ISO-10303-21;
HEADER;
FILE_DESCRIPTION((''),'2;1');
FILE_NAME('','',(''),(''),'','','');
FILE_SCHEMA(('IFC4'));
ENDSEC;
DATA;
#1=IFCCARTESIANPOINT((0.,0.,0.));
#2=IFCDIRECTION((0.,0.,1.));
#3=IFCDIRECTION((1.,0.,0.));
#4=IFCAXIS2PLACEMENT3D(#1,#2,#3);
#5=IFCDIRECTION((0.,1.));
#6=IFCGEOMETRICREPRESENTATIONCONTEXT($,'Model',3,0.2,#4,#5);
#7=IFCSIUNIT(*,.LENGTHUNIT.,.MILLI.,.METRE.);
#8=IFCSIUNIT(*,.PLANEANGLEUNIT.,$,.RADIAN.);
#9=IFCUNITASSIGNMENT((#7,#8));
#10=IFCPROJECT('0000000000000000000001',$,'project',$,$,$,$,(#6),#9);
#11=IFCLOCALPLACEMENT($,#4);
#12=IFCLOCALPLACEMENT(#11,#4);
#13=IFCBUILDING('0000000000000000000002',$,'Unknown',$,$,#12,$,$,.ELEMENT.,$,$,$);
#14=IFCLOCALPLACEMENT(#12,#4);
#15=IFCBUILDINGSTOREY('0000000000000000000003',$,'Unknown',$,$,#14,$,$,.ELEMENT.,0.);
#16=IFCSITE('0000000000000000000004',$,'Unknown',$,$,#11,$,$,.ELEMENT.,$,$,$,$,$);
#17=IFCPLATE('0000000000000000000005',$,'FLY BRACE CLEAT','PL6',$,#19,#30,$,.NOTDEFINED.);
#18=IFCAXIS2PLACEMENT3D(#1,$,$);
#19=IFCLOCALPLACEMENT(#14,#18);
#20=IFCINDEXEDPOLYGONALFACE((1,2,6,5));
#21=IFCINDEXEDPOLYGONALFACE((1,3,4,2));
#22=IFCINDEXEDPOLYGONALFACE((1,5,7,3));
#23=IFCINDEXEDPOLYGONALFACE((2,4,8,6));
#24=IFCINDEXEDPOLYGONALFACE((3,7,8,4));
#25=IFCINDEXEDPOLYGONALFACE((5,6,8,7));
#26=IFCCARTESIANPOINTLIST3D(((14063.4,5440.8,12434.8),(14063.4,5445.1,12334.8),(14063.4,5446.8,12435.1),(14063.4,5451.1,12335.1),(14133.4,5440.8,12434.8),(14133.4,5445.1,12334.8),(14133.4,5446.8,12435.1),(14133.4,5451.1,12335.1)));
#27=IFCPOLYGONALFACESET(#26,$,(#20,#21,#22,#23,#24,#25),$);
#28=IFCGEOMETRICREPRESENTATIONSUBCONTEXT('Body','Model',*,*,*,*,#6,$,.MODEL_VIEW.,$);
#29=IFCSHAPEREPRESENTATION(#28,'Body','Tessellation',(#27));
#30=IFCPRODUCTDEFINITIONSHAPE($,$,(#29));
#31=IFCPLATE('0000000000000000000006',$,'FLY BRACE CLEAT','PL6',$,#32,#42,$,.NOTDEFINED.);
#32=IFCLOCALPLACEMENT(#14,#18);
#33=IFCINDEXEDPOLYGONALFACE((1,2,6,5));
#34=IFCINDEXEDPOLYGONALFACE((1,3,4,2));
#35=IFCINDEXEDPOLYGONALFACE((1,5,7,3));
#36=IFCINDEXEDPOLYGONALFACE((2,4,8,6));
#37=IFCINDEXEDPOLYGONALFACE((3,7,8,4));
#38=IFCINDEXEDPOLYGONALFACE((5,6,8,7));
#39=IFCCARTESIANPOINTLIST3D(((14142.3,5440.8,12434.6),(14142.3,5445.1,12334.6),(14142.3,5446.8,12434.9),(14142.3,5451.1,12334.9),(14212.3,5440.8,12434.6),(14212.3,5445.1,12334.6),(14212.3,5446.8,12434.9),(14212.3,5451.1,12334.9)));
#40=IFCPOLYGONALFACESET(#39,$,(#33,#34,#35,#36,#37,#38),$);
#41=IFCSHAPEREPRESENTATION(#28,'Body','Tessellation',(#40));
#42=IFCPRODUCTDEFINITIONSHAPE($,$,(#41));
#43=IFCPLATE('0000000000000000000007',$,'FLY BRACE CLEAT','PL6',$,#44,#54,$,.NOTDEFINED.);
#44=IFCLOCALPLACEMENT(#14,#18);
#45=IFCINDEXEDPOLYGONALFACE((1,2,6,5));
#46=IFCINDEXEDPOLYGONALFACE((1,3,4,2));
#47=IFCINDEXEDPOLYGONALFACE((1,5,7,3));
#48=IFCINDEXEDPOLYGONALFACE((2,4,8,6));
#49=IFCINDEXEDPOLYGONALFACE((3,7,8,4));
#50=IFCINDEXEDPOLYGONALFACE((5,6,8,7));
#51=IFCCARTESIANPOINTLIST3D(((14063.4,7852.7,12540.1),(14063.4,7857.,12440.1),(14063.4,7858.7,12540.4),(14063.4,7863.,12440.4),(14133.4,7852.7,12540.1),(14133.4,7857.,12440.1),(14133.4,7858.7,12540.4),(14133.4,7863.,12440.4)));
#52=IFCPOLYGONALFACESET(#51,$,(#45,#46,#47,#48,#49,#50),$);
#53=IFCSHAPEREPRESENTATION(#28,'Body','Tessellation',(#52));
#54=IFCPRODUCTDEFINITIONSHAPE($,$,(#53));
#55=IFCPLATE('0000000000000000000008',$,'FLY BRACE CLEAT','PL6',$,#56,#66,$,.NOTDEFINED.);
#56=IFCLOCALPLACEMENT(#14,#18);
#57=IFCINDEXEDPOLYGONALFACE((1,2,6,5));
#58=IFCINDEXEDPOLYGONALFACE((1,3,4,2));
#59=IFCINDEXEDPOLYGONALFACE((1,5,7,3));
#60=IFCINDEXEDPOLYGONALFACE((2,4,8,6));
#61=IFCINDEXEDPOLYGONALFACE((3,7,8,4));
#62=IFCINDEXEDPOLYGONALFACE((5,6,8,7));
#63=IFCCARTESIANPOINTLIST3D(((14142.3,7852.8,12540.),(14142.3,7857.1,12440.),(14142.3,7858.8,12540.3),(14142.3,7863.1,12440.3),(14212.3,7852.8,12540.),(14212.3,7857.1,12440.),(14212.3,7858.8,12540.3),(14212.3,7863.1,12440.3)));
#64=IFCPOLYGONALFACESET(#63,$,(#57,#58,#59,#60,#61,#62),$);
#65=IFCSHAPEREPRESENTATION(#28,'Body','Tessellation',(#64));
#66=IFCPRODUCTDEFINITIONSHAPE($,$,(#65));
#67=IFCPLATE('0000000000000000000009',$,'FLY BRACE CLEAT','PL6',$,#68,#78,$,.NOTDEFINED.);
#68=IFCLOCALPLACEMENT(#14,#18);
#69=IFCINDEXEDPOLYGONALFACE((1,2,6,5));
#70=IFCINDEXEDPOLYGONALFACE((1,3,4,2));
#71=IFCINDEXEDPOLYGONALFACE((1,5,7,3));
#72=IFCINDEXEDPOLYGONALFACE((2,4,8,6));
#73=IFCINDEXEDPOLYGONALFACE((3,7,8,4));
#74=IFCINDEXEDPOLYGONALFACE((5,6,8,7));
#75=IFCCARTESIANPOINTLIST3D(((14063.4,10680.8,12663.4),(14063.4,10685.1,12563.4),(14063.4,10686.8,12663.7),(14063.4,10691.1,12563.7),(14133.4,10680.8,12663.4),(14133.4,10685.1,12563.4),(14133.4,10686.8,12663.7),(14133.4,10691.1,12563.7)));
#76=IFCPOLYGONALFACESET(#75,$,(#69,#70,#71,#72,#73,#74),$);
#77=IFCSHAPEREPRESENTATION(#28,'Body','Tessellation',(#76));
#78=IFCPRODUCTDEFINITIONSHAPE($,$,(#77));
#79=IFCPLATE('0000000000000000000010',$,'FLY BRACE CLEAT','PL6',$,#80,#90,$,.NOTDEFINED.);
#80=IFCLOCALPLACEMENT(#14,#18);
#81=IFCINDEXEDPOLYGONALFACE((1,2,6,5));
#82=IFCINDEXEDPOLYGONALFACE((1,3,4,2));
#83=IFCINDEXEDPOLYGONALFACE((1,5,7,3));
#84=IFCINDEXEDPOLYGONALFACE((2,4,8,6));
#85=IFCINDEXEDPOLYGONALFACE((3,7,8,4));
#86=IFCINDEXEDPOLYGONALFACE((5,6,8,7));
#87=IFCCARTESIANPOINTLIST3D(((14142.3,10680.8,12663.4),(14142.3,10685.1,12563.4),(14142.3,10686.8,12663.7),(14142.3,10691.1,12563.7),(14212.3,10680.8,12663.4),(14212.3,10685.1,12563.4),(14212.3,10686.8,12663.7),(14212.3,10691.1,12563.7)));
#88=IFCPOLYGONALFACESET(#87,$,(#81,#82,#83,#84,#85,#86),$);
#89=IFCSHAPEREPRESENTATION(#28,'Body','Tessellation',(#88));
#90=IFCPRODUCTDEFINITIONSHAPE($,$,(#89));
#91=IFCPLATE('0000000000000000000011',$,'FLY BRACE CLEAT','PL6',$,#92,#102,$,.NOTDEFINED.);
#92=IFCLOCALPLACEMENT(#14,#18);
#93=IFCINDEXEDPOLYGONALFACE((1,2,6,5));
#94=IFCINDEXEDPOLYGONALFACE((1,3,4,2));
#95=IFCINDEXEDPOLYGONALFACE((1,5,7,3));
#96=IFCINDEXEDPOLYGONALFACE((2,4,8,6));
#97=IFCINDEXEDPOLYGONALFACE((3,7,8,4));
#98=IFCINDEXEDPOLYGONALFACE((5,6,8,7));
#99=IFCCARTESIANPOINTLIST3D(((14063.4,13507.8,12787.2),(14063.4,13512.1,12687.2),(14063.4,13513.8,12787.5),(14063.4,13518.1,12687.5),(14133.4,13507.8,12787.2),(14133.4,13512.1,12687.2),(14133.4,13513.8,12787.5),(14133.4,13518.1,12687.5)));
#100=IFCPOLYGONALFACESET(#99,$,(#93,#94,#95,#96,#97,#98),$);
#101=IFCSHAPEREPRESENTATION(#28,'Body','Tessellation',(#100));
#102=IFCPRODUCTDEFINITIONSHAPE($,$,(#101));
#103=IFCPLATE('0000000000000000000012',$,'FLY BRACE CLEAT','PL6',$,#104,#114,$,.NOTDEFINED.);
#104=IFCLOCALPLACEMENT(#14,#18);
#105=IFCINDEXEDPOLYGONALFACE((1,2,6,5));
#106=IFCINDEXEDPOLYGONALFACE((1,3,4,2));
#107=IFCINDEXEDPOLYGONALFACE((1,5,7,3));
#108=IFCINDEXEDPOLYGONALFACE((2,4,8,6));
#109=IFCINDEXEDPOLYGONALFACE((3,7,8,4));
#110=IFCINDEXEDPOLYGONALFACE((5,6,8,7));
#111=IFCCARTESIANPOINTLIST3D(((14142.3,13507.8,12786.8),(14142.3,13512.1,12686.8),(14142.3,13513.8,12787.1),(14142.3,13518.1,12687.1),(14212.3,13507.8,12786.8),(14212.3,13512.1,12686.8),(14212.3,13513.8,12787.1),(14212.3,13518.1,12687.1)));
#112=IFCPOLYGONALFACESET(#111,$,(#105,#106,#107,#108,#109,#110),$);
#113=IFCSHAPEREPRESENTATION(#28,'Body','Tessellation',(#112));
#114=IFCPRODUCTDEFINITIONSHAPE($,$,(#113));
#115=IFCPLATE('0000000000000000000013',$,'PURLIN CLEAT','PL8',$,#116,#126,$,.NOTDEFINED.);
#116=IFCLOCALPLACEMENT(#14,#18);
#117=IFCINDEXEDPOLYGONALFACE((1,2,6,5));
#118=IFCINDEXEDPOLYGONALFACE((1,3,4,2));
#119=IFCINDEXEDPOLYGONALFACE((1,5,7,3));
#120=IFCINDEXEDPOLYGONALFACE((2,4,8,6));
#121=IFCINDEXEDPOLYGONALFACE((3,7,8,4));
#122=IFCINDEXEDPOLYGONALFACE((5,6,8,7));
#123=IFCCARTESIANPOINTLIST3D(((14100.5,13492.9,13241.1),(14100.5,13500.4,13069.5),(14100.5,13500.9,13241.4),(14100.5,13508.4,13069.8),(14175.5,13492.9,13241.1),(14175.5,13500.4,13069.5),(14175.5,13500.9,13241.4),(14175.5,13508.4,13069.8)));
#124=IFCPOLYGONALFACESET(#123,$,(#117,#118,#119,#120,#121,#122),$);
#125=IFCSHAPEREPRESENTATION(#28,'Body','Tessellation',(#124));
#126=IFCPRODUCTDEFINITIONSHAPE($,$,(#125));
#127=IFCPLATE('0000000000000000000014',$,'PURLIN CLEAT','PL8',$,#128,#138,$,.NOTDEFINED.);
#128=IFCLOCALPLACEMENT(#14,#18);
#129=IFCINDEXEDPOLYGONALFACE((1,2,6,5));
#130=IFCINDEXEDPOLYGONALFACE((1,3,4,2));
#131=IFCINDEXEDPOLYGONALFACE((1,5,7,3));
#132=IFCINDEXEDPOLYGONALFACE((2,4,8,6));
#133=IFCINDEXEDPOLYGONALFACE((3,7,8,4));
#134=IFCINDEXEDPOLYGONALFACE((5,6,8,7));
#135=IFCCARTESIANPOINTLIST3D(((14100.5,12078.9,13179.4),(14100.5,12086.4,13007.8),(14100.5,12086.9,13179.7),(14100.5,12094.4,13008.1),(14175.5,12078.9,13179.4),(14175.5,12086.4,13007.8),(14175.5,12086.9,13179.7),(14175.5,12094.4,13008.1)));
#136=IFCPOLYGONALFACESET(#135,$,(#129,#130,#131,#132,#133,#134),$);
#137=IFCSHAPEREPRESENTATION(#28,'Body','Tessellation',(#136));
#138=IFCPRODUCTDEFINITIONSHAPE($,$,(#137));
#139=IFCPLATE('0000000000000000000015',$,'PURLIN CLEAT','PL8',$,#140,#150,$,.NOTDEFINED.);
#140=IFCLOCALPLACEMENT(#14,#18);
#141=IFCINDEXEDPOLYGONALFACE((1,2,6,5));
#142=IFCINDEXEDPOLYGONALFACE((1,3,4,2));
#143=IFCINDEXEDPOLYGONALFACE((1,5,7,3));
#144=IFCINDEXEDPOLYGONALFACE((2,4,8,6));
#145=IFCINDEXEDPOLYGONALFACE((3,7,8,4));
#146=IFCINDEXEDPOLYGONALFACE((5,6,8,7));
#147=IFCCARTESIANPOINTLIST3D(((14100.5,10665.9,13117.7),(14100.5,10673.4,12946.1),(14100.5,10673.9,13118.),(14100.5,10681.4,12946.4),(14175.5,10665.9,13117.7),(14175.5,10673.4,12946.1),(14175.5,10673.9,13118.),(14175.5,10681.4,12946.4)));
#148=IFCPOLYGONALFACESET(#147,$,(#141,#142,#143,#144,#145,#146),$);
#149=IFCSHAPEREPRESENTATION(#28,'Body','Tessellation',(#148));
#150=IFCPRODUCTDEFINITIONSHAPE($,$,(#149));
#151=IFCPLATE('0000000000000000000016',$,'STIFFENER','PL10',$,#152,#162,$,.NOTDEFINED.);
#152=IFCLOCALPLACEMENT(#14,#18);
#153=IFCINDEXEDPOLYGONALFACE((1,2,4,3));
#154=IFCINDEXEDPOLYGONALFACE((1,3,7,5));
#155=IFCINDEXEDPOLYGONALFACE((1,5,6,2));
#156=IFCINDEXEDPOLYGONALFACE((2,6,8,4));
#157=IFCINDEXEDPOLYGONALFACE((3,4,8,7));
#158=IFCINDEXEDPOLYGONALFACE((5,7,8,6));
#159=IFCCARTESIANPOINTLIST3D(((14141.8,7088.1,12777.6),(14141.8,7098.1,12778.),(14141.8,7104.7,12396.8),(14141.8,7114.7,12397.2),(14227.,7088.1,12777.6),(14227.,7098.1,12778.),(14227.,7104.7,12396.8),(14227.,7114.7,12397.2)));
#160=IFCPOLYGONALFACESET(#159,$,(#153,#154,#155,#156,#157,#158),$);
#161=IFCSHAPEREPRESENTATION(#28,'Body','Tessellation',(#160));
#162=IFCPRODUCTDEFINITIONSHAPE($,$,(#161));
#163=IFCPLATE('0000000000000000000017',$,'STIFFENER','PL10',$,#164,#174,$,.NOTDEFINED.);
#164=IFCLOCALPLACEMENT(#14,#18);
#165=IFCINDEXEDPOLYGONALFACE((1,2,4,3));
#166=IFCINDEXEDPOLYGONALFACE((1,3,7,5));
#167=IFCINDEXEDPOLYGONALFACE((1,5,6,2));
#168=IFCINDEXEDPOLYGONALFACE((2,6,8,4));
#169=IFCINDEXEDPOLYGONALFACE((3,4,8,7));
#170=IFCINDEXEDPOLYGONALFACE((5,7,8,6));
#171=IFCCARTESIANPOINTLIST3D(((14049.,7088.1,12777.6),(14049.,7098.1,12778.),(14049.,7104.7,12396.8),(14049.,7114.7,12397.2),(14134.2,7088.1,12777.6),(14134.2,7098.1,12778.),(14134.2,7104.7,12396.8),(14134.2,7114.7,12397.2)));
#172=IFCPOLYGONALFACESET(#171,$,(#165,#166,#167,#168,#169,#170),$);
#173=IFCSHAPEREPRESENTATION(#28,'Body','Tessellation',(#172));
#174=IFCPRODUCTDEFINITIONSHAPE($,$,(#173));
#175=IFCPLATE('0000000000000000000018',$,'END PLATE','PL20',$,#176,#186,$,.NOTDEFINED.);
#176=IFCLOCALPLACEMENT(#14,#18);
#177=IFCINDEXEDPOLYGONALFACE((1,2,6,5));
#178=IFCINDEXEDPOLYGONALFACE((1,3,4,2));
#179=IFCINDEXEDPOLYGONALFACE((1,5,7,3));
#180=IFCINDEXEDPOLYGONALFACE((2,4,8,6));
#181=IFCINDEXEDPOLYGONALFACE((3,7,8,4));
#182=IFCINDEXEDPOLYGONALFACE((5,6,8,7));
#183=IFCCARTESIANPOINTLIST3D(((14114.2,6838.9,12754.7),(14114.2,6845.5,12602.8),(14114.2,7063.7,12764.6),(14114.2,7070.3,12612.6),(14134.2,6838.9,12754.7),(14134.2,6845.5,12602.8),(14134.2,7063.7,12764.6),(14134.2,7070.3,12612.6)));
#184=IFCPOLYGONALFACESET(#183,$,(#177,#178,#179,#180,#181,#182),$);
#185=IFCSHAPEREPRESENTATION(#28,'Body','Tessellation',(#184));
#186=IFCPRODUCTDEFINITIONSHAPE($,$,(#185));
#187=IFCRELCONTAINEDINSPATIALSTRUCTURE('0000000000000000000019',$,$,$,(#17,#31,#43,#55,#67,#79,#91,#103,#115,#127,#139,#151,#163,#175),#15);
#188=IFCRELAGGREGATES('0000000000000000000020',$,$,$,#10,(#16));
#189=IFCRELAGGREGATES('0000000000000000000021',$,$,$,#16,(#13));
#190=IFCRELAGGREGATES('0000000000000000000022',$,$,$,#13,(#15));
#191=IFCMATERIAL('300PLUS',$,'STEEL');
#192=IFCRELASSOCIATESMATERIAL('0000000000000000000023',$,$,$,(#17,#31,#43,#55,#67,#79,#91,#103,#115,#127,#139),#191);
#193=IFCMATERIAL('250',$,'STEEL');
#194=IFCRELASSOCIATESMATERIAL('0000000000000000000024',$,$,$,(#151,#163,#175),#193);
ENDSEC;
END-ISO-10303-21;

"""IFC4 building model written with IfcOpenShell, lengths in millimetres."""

from ifc_helpers import new_model, si_unit, direction, frame, origin_with_axes, place, context, subcontext, project, spatial, line, indexed_curve, outline, extrude, material, element, save


model = new_model("IFC4")

# Units and contexts
model_context = context("Model", 3, precision=0.2, world=origin_with_axes(), true_north=direction((0.0, 1.0)))
body_context = subcontext(model_context, "Body", "Model", "MODEL_VIEW")
ifc_project = project(units=[si_unit("LENGTHUNIT", "METRE", prefix="MILLI"), si_unit("PLANEANGLEUNIT", "RADIAN")], contexts=[model_context])

# Site, building, storey
site_placement = place(None, origin_with_axes())
site = spatial("IfcSite", under=ifc_project, at=site_placement, Name="Unknown", CompositionType="ELEMENT")
building_placement = place(site_placement, origin_with_axes())
building = spatial("IfcBuilding", under=site, at=building_placement, Name="Unknown", CompositionType="ELEMENT")
storey_placement = place(building_placement, origin_with_axes())
storey = spatial("IfcBuildingStorey", under=building, at=storey_placement, Name="Unknown", CompositionType="ELEMENT", Elevation=0.0)

# Shared definitions
ifc_material_1 = material(Name="300PLUS", Category="STEEL")

# Plates
for number, where, z_axis, x_axis, name in (
    (1, (14133.4, 5448.1, 12334.9), (0.0, 0.999077, 0.04296), (-1.0, 0.0, 0.0), "FLY BRACE CLEAT"),
    (2, (14142.3, 5443.8, 12434.7), (0.0, 0.999077, 0.04296), (1.0, 0.0, 0.0), "FLY BRACE CLEAT"),
    (3, (14133.4, 7860.0, 12440.2), (0.0, 0.999077, 0.04296), (-1.0, 0.0, 0.0), "FLY BRACE CLEAT"),
    (4, (14142.3, 7855.8, 12540.1), (0.0, 0.999077, 0.04296), (1.0, 0.0, 0.0), "FLY BRACE CLEAT"),
    (5, (14133.4, 10688.1, 12563.5), (0.0, 0.999077, 0.04296), (-1.0, 0.0, 0.0), "FLY BRACE CLEAT"),
    (6, (14142.3, 10683.8, 12663.5), (0.0, 0.999077, 0.04296), (1.0, 0.0, 0.0), "FLY BRACE CLEAT"),
    (7, (14133.4, 13515.1, 12687.3), (0.0, 0.999077, 0.04296), (-1.0, 0.0, 0.0), "FLY BRACE CLEAT"),
    (8, (14142.3, 13510.8, 12786.9), (0.0, 0.999077, 0.04296), (1.0, 0.0, 0.0), "FLY BRACE CLEAT"),
):
    element("IfcPlate", number, at=place(storey_placement, frame(where, z_axis=z_axis, x_axis=x_axis)), inside=storey, material=ifc_material_1, Name=name, Description="PL6", PredefinedType="NOTDEFINED", context=body_context, shape_type="SolidModel", body=[
        extrude(outline(indexed_curve([(0.0, 0.0), (70.0, 0.0), (70.0, 100.1), (0.0, 100.1)], segments=[line(1, 2, 3, 4, 1)])), frame((0.0, 0.0, 3.0), z_axis=(0.0, 0.0, 1.0), x_axis=(1.0, 0.0, 0.0)), (0.0, 0.0, -1.0), 6.0),
    ])
for number, where, z_axis, x_axis, name in (
    (9, (14100.5, 13496.9, 13241.3), (0.0, 0.999046, 0.043665), (1.0, 0.0, 0.0), "PURLIN CLEAT"),
    (10, (14100.5, 12082.9, 13179.6), (0.0, 0.999046, 0.043665), (1.0, 0.0, 0.0), "PURLIN CLEAT"),
    (11, (14100.5, 10669.9, 13117.9), (0.0, 0.999046, 0.043665), (1.0, 0.0, 0.0), "PURLIN CLEAT"),
):
    element("IfcPlate", number, at=place(storey_placement, frame(where, z_axis=z_axis, x_axis=x_axis)), inside=storey, material=ifc_material_1, Name=name, Description="PL8", PredefinedType="NOTDEFINED", context=body_context, shape_type="SolidModel", body=[
        extrude(outline(indexed_curve([(0.0, 0.0), (75.0, 0.0), (75.0, 171.8), (0.0, 171.8)], segments=[line(1, 2, 3, 4, 1)])), frame((0.0, 0.0, 4.0), z_axis=(0.0, 0.0, 1.0), x_axis=(1.0, 0.0, 0.0)), (0.0, 0.0, -1.0), 8.0),
    ])
ifc_material_2 = material(Name="250", Category="STEEL")
for number, where, z_axis, x_axis, name in (
    (12, (14227.0, 7109.7, 12397.0), (0.0, 0.999051, 0.043551), (-1.0, 0.0, 0.0), "STIFFENER"),
    (13, (14134.2, 7109.7, 12397.0), (0.0, 0.999051, 0.043551), (-1.0, 0.0, 0.0), "STIFFENER"),
):
    element("IfcPlate", number, at=place(storey_placement, frame(where, z_axis=z_axis, x_axis=x_axis)), inside=storey, material=ifc_material_2, Name=name, Description="PL10", PredefinedType="NOTDEFINED", context=body_context, shape_type="SolidModel", body=[
        extrude(outline(indexed_curve([(0.0, 0.0), (85.2, 0.0), (85.2, 381.2), (0.0, 381.2)], segments=[line(1, 2, 3, 4, 1)])), frame((0.0, 0.0, 5.0), z_axis=(0.0, 0.0, 1.0), x_axis=(1.0, 0.0, 0.0)), (0.0, 0.0, -1.0), 10.0),
    ])
plate_placement = place(storey_placement, frame((14124.2, 7070.3, 12612.6), z_axis=(-1.0, 0.0, 0.0), x_axis=(0.0, -0.999051, -0.043553)))
element("IfcPlate", 14, at=plate_placement, inside=storey, material=ifc_material_2, Name="END PLATE", Description="PL20", PredefinedType="NOTDEFINED", context=body_context, shape_type="SolidModel", body=[
    extrude(outline(indexed_curve([(0.0, 0.0), (225.0, 0.0), (225.0, 152.0), (0.0, 152.1)], segments=[line(1, 2, 3, 4, 1)])), frame((0.0, 0.0, 10.0), z_axis=(0.0, 0.0, 1.0), x_axis=(1.0, 0.0, 0.0)), (0.0, 0.0, -1.0), 20.0),
])

save(model, "model.ifc")
